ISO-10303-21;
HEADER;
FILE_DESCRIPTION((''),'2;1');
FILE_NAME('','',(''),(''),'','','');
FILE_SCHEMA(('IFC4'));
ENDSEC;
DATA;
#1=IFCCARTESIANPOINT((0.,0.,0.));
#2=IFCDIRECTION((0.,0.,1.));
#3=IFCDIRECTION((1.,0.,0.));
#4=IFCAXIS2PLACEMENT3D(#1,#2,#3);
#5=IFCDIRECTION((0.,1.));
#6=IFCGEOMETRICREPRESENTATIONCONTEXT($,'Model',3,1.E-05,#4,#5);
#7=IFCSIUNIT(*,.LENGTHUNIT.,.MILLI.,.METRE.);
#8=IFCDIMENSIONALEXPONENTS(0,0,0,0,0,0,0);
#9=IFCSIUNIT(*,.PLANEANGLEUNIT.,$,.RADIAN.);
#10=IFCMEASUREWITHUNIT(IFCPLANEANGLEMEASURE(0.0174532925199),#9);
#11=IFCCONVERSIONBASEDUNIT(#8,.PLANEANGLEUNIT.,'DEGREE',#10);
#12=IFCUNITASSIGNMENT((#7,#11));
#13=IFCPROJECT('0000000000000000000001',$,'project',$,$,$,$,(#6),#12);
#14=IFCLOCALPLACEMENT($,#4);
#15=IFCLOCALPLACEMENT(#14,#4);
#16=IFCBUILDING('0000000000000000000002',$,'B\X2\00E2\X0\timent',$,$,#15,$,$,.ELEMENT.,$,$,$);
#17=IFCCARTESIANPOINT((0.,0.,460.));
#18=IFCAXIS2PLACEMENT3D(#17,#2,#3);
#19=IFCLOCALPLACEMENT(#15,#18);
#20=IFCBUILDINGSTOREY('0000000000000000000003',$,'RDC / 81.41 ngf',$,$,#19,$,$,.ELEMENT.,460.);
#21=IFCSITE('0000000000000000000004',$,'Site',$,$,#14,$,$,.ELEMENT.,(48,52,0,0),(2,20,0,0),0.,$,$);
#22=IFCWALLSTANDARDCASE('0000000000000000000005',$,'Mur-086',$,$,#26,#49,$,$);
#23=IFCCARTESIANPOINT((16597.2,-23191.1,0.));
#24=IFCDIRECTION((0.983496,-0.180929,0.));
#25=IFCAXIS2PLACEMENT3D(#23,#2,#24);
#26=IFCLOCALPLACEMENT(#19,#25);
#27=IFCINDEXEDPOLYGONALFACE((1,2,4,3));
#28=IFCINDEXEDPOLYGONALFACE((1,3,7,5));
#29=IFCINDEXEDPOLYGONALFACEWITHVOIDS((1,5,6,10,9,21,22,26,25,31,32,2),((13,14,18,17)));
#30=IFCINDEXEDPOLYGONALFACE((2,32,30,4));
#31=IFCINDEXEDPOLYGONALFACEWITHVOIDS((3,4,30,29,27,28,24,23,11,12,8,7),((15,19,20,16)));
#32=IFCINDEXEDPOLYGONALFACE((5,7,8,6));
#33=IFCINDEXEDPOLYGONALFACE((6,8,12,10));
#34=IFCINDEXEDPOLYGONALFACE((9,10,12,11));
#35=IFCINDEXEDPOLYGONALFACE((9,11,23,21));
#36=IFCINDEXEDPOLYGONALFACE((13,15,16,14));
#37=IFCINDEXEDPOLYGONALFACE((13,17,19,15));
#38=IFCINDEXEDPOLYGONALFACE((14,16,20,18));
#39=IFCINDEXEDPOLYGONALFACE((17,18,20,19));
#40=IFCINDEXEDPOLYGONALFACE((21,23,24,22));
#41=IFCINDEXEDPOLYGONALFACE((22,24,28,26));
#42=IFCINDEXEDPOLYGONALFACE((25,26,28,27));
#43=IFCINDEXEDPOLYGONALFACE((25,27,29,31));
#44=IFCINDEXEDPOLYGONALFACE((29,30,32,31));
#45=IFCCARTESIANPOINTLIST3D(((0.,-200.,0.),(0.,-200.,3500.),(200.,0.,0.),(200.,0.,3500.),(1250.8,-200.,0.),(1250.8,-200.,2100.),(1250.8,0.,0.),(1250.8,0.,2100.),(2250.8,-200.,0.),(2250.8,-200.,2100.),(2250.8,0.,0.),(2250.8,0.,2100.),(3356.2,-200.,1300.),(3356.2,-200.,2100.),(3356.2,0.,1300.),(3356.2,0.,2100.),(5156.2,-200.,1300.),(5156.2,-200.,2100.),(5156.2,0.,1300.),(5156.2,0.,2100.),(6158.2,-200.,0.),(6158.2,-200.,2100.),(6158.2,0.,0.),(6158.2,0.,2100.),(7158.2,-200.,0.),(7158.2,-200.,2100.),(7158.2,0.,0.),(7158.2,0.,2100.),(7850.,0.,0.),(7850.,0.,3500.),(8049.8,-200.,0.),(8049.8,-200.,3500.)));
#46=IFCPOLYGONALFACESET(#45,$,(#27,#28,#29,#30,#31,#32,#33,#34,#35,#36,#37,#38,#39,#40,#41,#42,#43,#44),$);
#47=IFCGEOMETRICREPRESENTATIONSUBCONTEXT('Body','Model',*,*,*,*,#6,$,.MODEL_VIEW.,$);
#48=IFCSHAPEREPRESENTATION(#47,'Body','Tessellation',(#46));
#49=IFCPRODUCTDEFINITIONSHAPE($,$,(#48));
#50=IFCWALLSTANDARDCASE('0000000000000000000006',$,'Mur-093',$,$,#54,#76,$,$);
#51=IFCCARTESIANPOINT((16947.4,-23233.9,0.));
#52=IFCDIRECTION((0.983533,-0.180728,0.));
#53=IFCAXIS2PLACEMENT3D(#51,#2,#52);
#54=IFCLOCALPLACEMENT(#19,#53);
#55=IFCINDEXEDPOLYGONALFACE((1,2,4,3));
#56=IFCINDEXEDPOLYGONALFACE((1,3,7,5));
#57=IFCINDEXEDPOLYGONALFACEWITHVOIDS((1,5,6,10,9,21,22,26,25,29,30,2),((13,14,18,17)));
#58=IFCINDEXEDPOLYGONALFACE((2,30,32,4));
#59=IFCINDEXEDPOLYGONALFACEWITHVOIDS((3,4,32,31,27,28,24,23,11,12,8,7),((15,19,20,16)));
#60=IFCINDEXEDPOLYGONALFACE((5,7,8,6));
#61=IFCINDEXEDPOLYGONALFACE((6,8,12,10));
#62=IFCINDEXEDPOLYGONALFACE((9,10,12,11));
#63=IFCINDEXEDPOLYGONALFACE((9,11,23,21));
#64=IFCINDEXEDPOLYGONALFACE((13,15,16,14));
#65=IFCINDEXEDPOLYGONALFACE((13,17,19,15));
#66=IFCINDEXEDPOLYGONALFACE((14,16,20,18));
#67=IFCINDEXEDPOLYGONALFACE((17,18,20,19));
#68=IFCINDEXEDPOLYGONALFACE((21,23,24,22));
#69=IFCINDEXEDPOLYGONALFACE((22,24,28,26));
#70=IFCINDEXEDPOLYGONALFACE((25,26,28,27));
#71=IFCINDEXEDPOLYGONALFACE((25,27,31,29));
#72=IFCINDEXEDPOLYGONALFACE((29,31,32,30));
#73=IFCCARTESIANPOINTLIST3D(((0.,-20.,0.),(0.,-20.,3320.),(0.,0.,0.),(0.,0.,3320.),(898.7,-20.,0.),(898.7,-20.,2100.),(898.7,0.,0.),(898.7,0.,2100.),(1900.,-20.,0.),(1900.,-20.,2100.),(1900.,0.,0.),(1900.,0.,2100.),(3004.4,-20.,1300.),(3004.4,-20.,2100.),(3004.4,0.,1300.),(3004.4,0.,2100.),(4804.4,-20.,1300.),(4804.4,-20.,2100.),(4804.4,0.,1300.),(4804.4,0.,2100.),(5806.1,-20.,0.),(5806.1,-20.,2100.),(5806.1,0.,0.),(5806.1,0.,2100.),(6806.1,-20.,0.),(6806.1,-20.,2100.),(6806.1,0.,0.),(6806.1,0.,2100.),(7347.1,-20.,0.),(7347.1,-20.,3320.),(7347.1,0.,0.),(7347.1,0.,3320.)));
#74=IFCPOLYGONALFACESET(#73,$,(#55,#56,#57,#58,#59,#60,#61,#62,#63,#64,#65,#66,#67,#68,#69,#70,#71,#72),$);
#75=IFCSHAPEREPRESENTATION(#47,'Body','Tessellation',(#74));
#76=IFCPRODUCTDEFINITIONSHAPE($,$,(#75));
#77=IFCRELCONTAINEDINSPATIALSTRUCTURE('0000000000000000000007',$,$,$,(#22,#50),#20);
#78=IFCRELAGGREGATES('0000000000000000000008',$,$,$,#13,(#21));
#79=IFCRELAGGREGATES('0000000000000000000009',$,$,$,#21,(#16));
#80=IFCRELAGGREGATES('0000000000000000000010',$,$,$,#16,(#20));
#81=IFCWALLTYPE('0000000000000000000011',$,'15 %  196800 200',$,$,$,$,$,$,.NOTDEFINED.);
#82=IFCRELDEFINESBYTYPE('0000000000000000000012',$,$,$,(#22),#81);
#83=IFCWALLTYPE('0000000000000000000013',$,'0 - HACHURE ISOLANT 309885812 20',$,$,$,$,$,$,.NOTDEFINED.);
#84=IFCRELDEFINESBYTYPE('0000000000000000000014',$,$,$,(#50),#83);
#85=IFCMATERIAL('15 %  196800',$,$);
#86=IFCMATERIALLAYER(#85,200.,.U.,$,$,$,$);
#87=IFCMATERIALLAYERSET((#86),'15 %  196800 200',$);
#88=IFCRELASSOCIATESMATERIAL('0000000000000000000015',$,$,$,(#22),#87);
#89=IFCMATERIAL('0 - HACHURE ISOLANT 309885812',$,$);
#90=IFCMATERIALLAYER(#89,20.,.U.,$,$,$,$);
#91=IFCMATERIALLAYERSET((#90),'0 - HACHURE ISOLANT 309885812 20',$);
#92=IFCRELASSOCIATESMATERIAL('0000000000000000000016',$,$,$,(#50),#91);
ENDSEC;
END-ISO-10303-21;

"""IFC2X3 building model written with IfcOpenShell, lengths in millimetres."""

from ifc_helpers import new_model, entity, si_unit, converted_unit, direction, frame, origin_with_axes, origin_2d_with_axis, place, context, subcontext, project, spatial, polyline, rectangle, outline, extrude, material, layer, layer_set, layer_usage, type_object, element, save


model = new_model("IFC2X3")

# Units and contexts
model_context = context("Model", 3, precision=1e-05, world=origin_with_axes(), true_north=direction((0.0, 1.0)))
body_context = subcontext(model_context, "Body", "Model", "MODEL_VIEW")
ifc_project = project(units=[si_unit("LENGTHUNIT", "METRE", prefix="MILLI"), converted_unit("PLANEANGLEUNIT", "DEGREE", entity("IfcPlaneAngleMeasure", 0.0174532925199), si_unit("PLANEANGLEUNIT", "RADIAN"), dimensions=[0, 0, 0, 0, 0, 0, 0])], contexts=[model_context])

# Site, building, storey
site_placement = place(None, origin_with_axes())
site = spatial("IfcSite", under=ifc_project, at=site_placement, Name="Site", CompositionType="ELEMENT", RefLatitude=(48, 52, 0, 0), RefLongitude=(2, 20, 0, 0), RefElevation=0.0)
building_placement = place(site_placement, origin_with_axes())
building = spatial("IfcBuilding", under=site, at=building_placement, Name="Bâtiment", CompositionType="ELEMENT")
storey_placement = place(building_placement, frame((0.0, 0.0, 460.0), z_axis=(0.0, 0.0, 1.0), x_axis=(1.0, 0.0, 0.0)))
storey = spatial("IfcBuildingStorey", under=building, at=storey_placement, Name="RDC / 81.41 ngf", CompositionType="ELEMENT", Elevation=460.0)

# Shared definitions
ifc_material_1 = material(Name="15 %  196800")

# Wall, openings
ifc_layer_1 = layer(ifc_material_1, 200.0, ventilated="UNKNOWN")
ifc_layer_set_1 = layer_set([ifc_layer_1], Name="15 %  196800 200")
ifc_layer_usage_1 = layer_usage(ifc_layer_set_1, "AXIS2", "POSITIVE", -200.0)
wall_type_1 = type_object("IfcWallType", Name="15 %  196800 200", PredefinedType="NOTDEFINED")
wall_1_placement = place(storey_placement, frame((16597.2, -23191.1, 0.0), z_axis=(0.0, 0.0, 1.0), x_axis=(0.983496, -0.180929, 0.0)))
wall_1 = element("IfcWallStandardCase", 1, at=wall_1_placement, inside=storey, type_object=wall_type_1, material=ifc_layer_usage_1, Name="Mur-086", context=body_context, shape_type="SweptSolid", body=[
    extrude(outline(polyline([(0.0, -200.0), (8049.8, -200.0), (7850.0, 0.0), (200.0, 0.0), (0.0, -200.0)])), origin_with_axes(), (0.0, 0.0, 1.0), 3500.0),
])
opening_1_placement = place(wall_1_placement, frame((4256.2, 0.0, 1300.0), z_axis=(0.0, 0.0, 1.0), x_axis=(1.0, 0.0, 0.0)))
element("IfcOpeningElement", 2, at=opening_1_placement, cuts=wall_1, context=body_context, shape_type="SweptSolid", body=[
    extrude(rectangle(XDim=1800.0, YDim=800.0, at=origin_2d_with_axis()), frame((0.0, -400.0, 400.0), z_axis=(0.0, -1.0, 0.0), x_axis=(1.0, 0.0, 0.0)), (0.0, 0.0, -1.0), 600.0),
])
opening_2_placement = place(wall_1_placement, frame((1750.8, 0.0, 0.0), z_axis=(0.0, 0.0, 1.0), x_axis=(1.0, 0.0, 0.0)))
element("IfcOpeningElement", 3, at=opening_2_placement, cuts=wall_1, context=body_context, shape_type="SweptSolid", body=[
    extrude(rectangle(XDim=1000.0, YDim=2100.0, at=origin_2d_with_axis()), frame((0.0, 200.0, 1050.0), z_axis=(0.0, -1.0, 0.0), x_axis=(1.0, 0.0, 0.0)), (0.0, 0.0, 1.0), 600.0),
])
opening_3_placement = place(wall_1_placement, frame((6658.2, 0.0, 0.0), z_axis=(0.0, 0.0, 1.0), x_axis=(1.0, 0.0, 0.0)))
element("IfcOpeningElement", 4, at=opening_3_placement, cuts=wall_1, context=body_context, shape_type="SweptSolid", body=[
    extrude(rectangle(XDim=1000.0, YDim=2100.0, at=origin_2d_with_axis()), frame((0.0, 200.0, 1050.0), z_axis=(0.0, -1.0, 0.0), x_axis=(1.0, 0.0, 0.0)), (0.0, 0.0, 1.0), 600.0),
])

# Shared definitions
ifc_material_2 = material(Name="0 - HACHURE ISOLANT 309885812")

# Wall, openings
ifc_layer_2 = layer(ifc_material_2, 20.0, ventilated="UNKNOWN")
ifc_layer_set_2 = layer_set([ifc_layer_2], Name="0 - HACHURE ISOLANT 309885812 20")
ifc_layer_usage_2 = layer_usage(ifc_layer_set_2, "AXIS2", "POSITIVE", -20.0)
wall_type_2 = type_object("IfcWallType", Name="0 - HACHURE ISOLANT 309885812 20", PredefinedType="NOTDEFINED")
wall_2_placement = place(storey_placement, frame((16947.4, -23233.9, 0.0), z_axis=(0.0, 0.0, 1.0), x_axis=(0.983533, -0.180728, 0.0)))
wall_2 = element("IfcWallStandardCase", 5, at=wall_2_placement, inside=storey, type_object=wall_type_2, material=ifc_layer_usage_2, Name="Mur-093", context=body_context, shape_type="SweptSolid", body=[
    extrude(outline(polyline([(0.0, -20.0), (7347.1, -20.0), (7347.1, 0.0), (0.0, 0.0), (0.0, -20.0)])), origin_with_axes(), (0.0, 0.0, 1.0), 3320.0),
])
opening_4_placement = place(wall_2_placement, frame((3904.4, 0.0, 1300.0), z_axis=(0.0, 0.0, 1.0), x_axis=(1.0, 0.0, 0.0)))
element("IfcOpeningElement", 6, at=opening_4_placement, cuts=wall_2, context=body_context, shape_type="SweptSolid", body=[
    extrude(rectangle(XDim=1800.0, YDim=800.0, at=origin_2d_with_axis()), frame((0.0, -40.0, 400.0), z_axis=(0.0, -1.0, 0.0), x_axis=(1.0, 0.0, 0.0)), (0.0, 0.0, -1.0), 60.0),
])
opening_5_placement = place(wall_2_placement, frame((1399.3, 0.0, 0.0), z_axis=(0.0, 0.0, 1.0), x_axis=(1.0, 0.0, 0.0)))
element("IfcOpeningElement", 7, at=opening_5_placement, cuts=wall_2, context=body_context, shape_type="SweptSolid", body=[
    extrude(rectangle(XDim=1001.3, YDim=2100.0, at=origin_2d_with_axis()), frame((0.0, -40.0, 1050.0), z_axis=(0.0, -1.0, 0.0), x_axis=(1.0, 0.0, 0.0)), (0.0, 0.0, -1.0), 60.0),
])
opening_6_placement = place(wall_2_placement, frame((6306.1, 0.0, 0.0), z_axis=(0.0, 0.0, 1.0), x_axis=(1.0, 0.0, 0.0)))
element("IfcOpeningElement", 8, at=opening_6_placement, cuts=wall_2, context=body_context, shape_type="SweptSolid", body=[
    extrude(rectangle(XDim=1000.0, YDim=2100.0, at=origin_2d_with_axis()), frame((0.0, -40.0, 1050.0), z_axis=(0.0, -1.0, 0.0), x_axis=(1.0, 0.0, 0.0)), (0.0, 0.0, -1.0), 60.0),
])

save(model, "model.ifc")
